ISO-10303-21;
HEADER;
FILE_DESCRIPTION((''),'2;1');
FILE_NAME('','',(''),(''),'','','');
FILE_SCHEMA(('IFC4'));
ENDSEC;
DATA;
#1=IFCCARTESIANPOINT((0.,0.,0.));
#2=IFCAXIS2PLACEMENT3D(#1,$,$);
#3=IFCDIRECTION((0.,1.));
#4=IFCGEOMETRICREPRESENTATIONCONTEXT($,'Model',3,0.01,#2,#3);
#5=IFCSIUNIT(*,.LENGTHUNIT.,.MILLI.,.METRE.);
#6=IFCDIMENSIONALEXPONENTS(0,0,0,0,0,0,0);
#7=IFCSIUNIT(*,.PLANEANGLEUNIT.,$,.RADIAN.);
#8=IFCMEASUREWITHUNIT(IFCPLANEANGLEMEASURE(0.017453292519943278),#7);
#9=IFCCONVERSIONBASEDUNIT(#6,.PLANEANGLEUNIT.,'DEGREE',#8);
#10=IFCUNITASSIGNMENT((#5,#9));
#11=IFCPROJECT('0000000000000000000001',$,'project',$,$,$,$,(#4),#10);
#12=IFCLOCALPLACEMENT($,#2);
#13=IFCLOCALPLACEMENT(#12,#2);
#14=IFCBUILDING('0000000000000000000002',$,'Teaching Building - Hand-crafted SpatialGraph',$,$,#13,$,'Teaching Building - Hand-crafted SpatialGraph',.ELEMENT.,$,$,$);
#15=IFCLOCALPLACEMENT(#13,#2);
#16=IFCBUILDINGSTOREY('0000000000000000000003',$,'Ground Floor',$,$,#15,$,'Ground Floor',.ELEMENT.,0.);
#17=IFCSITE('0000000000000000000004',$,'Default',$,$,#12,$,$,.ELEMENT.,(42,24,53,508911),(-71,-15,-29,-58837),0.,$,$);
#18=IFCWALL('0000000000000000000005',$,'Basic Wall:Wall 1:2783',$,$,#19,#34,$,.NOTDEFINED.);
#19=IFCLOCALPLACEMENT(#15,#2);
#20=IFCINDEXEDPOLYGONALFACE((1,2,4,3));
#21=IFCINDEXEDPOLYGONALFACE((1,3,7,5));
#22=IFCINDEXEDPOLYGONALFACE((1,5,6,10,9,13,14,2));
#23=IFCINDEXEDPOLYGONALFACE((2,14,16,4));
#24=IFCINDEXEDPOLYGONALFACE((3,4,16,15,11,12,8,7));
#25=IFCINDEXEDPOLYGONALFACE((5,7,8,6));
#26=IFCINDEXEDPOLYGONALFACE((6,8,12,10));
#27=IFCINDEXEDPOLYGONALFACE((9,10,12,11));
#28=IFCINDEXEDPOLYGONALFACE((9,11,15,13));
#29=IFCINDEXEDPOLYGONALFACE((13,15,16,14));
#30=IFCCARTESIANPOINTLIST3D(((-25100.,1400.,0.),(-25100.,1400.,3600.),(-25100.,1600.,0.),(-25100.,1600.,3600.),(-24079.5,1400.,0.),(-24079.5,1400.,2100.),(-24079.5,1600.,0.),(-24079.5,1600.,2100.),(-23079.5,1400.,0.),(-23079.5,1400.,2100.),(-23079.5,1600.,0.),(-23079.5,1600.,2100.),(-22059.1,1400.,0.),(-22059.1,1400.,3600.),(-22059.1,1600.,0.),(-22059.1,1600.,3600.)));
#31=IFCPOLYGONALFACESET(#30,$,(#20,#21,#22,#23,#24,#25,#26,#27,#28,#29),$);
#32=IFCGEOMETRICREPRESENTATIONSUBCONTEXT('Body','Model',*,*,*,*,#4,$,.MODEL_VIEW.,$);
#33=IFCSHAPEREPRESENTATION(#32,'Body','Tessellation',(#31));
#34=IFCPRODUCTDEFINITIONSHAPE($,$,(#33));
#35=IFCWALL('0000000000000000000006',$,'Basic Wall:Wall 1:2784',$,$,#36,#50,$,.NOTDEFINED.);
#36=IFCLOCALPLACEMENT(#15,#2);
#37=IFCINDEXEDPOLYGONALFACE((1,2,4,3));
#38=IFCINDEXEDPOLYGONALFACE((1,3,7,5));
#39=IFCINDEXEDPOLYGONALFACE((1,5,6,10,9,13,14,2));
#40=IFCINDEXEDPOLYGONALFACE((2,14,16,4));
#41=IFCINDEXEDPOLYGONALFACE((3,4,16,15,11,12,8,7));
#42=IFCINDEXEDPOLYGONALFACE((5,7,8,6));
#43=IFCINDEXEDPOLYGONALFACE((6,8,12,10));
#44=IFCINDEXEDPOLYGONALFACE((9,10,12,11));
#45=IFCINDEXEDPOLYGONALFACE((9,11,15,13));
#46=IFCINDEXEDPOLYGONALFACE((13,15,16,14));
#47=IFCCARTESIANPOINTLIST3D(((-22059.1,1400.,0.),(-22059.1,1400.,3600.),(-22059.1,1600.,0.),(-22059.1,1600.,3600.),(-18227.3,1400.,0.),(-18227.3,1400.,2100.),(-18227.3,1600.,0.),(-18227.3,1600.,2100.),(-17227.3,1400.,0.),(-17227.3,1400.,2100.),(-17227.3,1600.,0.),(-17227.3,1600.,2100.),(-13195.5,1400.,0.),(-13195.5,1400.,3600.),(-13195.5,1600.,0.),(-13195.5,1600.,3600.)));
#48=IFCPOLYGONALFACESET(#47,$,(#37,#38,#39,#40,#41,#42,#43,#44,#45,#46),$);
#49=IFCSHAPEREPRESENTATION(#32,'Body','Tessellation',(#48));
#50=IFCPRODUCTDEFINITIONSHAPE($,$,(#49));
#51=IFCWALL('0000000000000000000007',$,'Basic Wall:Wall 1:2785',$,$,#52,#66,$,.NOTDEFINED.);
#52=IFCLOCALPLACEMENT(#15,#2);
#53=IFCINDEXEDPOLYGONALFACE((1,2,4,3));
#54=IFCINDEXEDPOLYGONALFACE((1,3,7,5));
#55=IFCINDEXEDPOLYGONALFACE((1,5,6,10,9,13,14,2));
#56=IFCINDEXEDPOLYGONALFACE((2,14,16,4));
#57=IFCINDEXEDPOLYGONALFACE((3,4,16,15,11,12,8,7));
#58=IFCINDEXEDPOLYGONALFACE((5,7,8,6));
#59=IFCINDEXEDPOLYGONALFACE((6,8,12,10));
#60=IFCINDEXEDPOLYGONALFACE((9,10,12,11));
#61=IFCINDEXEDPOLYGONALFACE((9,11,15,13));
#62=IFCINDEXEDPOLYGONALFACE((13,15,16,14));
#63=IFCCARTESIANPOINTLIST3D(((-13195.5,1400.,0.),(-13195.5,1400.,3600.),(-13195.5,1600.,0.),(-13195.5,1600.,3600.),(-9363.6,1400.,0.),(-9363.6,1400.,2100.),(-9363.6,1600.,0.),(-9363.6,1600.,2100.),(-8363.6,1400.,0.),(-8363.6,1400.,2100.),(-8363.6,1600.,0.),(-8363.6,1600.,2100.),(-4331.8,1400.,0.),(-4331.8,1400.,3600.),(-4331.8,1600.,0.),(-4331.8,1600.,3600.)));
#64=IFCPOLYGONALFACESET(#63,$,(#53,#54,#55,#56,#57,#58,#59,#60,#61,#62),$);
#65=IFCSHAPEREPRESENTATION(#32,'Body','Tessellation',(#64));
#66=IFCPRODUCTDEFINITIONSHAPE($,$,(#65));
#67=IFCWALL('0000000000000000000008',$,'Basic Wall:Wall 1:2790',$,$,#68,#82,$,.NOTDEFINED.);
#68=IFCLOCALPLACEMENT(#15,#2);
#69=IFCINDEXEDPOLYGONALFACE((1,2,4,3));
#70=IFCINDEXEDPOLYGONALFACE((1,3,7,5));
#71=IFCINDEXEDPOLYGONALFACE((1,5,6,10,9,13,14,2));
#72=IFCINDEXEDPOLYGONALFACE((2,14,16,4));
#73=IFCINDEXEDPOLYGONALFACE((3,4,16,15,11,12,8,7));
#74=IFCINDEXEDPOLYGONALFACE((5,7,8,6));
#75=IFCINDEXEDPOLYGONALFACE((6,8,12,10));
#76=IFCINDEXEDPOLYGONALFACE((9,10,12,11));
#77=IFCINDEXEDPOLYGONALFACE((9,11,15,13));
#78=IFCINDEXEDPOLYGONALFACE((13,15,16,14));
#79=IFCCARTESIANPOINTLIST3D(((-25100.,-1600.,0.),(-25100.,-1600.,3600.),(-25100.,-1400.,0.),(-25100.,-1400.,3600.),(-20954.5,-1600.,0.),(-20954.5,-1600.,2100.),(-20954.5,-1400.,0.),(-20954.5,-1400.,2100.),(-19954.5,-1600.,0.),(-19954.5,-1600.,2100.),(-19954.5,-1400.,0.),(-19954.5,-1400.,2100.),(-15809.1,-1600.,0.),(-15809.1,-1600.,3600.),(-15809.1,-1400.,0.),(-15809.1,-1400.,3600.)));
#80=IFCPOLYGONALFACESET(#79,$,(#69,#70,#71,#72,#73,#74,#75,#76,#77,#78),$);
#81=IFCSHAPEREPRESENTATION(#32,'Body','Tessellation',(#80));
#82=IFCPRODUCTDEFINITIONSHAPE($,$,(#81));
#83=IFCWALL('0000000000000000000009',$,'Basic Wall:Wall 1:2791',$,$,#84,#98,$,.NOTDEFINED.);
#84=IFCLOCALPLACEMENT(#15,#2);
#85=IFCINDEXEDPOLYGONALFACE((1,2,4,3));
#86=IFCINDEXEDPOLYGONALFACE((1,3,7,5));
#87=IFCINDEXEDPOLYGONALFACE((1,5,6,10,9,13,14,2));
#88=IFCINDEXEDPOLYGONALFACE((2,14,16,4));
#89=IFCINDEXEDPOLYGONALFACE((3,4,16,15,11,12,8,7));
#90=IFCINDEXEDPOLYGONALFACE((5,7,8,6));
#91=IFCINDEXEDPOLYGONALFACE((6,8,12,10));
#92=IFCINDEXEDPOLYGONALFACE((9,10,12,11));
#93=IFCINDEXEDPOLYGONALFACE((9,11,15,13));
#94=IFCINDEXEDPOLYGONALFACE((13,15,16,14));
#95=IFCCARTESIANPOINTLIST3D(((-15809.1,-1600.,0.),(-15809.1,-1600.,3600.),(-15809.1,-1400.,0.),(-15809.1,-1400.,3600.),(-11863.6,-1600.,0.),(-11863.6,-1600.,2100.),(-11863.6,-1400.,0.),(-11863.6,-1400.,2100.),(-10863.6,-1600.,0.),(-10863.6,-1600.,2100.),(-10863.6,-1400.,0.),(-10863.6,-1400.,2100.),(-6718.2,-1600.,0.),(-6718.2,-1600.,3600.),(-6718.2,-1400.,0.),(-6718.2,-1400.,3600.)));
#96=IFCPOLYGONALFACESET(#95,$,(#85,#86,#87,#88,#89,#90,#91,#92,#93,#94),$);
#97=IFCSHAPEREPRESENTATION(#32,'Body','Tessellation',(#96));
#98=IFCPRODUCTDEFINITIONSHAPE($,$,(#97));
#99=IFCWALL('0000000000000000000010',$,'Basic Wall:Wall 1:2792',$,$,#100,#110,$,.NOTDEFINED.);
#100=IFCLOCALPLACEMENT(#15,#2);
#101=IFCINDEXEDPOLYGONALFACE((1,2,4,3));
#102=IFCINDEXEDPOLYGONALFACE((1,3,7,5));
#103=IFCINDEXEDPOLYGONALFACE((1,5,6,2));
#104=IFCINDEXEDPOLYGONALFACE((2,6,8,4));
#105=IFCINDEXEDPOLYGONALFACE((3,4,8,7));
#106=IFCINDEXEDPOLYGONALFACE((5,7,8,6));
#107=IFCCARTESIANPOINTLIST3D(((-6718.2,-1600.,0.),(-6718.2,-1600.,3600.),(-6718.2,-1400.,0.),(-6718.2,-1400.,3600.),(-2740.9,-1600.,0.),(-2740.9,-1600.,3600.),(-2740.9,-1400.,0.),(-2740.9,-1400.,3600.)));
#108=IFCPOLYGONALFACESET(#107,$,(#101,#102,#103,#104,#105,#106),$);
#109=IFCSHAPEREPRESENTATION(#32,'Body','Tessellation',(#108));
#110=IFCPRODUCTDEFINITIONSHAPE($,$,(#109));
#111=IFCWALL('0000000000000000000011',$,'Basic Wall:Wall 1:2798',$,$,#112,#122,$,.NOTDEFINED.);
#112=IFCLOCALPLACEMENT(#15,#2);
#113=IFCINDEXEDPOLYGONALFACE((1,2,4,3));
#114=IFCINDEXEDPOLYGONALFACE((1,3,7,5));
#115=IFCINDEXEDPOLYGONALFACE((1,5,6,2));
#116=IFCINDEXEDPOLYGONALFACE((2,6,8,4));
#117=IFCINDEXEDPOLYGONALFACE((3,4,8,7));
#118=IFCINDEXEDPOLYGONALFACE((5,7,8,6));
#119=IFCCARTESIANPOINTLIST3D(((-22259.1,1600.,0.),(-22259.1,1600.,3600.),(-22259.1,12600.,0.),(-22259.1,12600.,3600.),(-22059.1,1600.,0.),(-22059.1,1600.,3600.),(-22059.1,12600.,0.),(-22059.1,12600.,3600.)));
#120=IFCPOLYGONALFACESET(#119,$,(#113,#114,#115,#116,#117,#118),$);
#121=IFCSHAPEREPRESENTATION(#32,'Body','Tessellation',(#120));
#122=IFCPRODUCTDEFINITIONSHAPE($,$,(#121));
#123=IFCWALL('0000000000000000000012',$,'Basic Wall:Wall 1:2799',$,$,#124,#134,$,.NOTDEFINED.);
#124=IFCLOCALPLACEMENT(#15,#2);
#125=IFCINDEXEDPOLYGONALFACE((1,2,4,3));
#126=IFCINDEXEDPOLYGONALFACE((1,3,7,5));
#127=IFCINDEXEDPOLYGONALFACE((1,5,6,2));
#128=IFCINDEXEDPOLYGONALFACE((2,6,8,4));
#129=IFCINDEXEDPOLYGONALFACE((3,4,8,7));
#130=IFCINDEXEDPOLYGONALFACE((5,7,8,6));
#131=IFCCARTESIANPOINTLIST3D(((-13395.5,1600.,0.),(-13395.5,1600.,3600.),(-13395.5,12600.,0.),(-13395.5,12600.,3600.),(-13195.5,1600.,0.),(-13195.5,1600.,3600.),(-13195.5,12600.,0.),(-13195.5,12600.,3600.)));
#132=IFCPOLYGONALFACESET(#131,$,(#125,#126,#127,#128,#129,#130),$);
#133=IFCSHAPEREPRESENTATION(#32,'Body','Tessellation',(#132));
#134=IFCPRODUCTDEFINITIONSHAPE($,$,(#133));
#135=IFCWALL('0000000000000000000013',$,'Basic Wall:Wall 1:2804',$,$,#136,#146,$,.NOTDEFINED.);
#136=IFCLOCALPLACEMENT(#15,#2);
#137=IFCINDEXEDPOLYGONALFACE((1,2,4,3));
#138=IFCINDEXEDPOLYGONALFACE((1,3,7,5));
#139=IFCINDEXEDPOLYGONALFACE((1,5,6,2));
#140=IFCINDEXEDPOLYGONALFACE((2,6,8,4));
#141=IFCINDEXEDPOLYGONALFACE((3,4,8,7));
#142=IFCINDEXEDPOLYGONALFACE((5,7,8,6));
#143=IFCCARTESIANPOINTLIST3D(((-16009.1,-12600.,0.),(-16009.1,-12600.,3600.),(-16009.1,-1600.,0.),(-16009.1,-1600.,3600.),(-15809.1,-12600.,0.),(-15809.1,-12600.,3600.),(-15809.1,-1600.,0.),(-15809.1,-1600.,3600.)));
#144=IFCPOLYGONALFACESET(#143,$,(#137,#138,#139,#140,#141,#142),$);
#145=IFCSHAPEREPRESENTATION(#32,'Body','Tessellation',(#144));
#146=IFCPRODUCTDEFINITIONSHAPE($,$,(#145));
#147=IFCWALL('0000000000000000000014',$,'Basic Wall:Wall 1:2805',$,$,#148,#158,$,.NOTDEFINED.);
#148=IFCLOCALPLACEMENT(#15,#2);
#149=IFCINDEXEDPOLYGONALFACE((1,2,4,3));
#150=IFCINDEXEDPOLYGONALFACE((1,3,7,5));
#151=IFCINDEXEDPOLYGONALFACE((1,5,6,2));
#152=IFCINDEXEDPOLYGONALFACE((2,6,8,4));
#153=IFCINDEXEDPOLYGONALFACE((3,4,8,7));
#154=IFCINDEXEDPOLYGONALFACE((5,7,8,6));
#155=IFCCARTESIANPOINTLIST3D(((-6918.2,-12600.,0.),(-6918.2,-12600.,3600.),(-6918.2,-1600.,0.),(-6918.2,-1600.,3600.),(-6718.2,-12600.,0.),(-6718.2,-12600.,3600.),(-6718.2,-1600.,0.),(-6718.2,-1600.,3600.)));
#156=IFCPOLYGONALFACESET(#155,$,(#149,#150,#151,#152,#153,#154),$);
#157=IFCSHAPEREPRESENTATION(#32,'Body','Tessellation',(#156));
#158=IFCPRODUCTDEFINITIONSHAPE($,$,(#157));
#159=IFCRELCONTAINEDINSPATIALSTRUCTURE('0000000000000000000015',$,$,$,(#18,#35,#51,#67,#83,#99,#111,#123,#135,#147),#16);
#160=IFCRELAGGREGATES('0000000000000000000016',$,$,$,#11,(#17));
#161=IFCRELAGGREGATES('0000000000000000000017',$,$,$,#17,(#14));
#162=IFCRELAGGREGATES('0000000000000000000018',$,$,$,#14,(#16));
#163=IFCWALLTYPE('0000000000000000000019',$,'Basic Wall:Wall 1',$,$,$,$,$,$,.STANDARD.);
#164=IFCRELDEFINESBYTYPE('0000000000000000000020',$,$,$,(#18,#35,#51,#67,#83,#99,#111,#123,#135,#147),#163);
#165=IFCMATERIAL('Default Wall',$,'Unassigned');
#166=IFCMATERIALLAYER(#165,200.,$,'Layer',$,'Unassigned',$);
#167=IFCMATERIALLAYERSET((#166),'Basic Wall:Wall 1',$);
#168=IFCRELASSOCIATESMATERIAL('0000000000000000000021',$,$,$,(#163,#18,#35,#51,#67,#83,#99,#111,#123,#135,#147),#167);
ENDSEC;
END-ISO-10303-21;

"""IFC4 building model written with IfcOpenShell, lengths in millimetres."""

from ifc_helpers import new_model, entity, si_unit, converted_unit, direction, frame, frame_2d, origin, origin_2d_with_axis, place, context, subcontext, project, spatial, rectangle, extrude, material, layer, layer_set, layer_usage, type_object, element, save


model = new_model("IFC4")

# Units and contexts
model_context = context("Model", 3, precision=0.01, world=origin(), true_north=direction((0.0, 1.0)))
body_context = subcontext(model_context, "Body", "Model", "MODEL_VIEW")
ifc_project = project(units=[si_unit("LENGTHUNIT", "METRE", prefix="MILLI"), converted_unit("PLANEANGLEUNIT", "DEGREE", entity("IfcPlaneAngleMeasure", 0.017453292519943278), si_unit("PLANEANGLEUNIT", "RADIAN"), dimensions=[0, 0, 0, 0, 0, 0, 0])], contexts=[model_context])

# Site, building, storey
site_placement = place(None, origin())
site = spatial("IfcSite", under=ifc_project, at=site_placement, Name="Default", CompositionType="ELEMENT", RefLatitude=(42, 24, 53, 508911), RefLongitude=(-71, -15, -29, -58837), RefElevation=0.0)
building_placement = place(site_placement, origin())
building = spatial("IfcBuilding", under=site, at=building_placement, Name="Teaching Building - Hand-crafted SpatialGraph", LongName="Teaching Building - Hand-crafted SpatialGraph", CompositionType="ELEMENT")
storey_placement = place(building_placement, origin())
storey = spatial("IfcBuildingStorey", under=building, at=storey_placement, Name="Ground Floor", LongName="Ground Floor", CompositionType="ELEMENT", Elevation=0.0)

# Walls, openings
ifc_material = material(Name="Default Wall", Category="Unassigned")
ifc_layer = layer(ifc_material, 200.0, Name="Layer", Category="Unassigned")
ifc_layer_set = layer_set([ifc_layer], Name="Basic Wall:Wall 1")
ifc_layer_usage_1 = layer_usage(ifc_layer_set, "AXIS2", "NEGATIVE", 100.0)
wall_type = type_object("IfcWallType", Name="Basic Wall:Wall 1", PredefinedType="STANDARD", material=ifc_layer_set)
wall_1_placement = place(storey_placement, frame((-25100.0, 1500.0, 0.0)))
wall_1 = element("IfcWall", 1, at=wall_1_placement, inside=storey, type_object=wall_type, material=ifc_layer_usage_1, Name="Basic Wall:Wall 1:2783", PredefinedType="NOTDEFINED", context=body_context, shape_type="SweptSolid", body=[
    extrude(rectangle(XDim=3040.9, YDim=200.0, at=frame_2d((1520.5, 0.0), x_axis=(1.0, 0.0))), origin(), (0.0, 0.0, 1.0), 3600.0),
])
opening_1_placement = place(wall_1_placement, origin())
element("IfcOpeningElement", 2, at=opening_1_placement, cuts=wall_1, PredefinedType="OPENING", context=body_context, shape_type="SweptSolid", body=[
    extrude(rectangle(XDim=2100.0, YDim=1000.0, at=frame_2d((0.0, 0.0), x_axis=(1.0, 0.0))), frame((1520.5, -100.0, 1050.0), z_axis=(0.0, 1.0, 0.0), x_axis=(0.0, 0.0, -1.0)), (0.0, 0.0, 1.0), 200.0),
])
ifc_layer_usage_2 = layer_usage(ifc_layer_set, "AXIS2", "NEGATIVE", 100.0)
wall_2_placement = place(storey_placement, frame((-22059.1, 1500.0, 0.0)))
wall_2 = element("IfcWall", 3, at=wall_2_placement, inside=storey, type_object=wall_type, material=ifc_layer_usage_2, Name="Basic Wall:Wall 1:2784", PredefinedType="NOTDEFINED", context=body_context, shape_type="SweptSolid", body=[
    extrude(rectangle(XDim=8863.6, YDim=200.0, at=frame_2d((4431.8, 0.0), x_axis=(1.0, 0.0))), origin(), (0.0, 0.0, 1.0), 3600.0),
])
opening_2_placement = place(wall_2_placement, origin())
element("IfcOpeningElement", 4, at=opening_2_placement, cuts=wall_2, PredefinedType="OPENING", context=body_context, shape_type="SweptSolid", body=[
    extrude(rectangle(XDim=2100.0, YDim=1000.0, at=frame_2d((0.0, 0.0), x_axis=(1.0, 0.0))), frame((4331.8, -100.0, 1050.0), z_axis=(0.0, 1.0, 0.0), x_axis=(0.0, 0.0, -1.0)), (0.0, 0.0, 1.0), 200.0),
])
ifc_layer_usage_3 = layer_usage(ifc_layer_set, "AXIS2", "NEGATIVE", 100.0)
wall_3_placement = place(storey_placement, frame((-13195.5, 1500.0, 0.0)))
wall_3 = element("IfcWall", 5, at=wall_3_placement, inside=storey, type_object=wall_type, material=ifc_layer_usage_3, Name="Basic Wall:Wall 1:2785", PredefinedType="NOTDEFINED", context=body_context, shape_type="SweptSolid", body=[
    extrude(rectangle(XDim=8863.6, YDim=200.0, at=frame_2d((4431.8, 0.0), x_axis=(1.0, 0.0))), origin(), (0.0, 0.0, 1.0), 3600.0),
])
opening_3_placement = place(wall_3_placement, origin())
element("IfcOpeningElement", 6, at=opening_3_placement, cuts=wall_3, PredefinedType="OPENING", context=body_context, shape_type="SweptSolid", body=[
    extrude(rectangle(XDim=2100.0, YDim=1000.0, at=origin_2d_with_axis()), frame((4331.8, -100.0, 1050.0), z_axis=(0.0, 1.0, 0.0), x_axis=(0.0, 0.0, -1.0)), (0.0, 0.0, 1.0), 200.0),
])
ifc_layer_usage_4 = layer_usage(ifc_layer_set, "AXIS2", "NEGATIVE", 100.0)
wall_4_placement = place(storey_placement, frame((-25100.0, -1500.0, 0.0)))
wall_4 = element("IfcWall", 7, at=wall_4_placement, inside=storey, type_object=wall_type, material=ifc_layer_usage_4, Name="Basic Wall:Wall 1:2790", PredefinedType="NOTDEFINED", context=body_context, shape_type="SweptSolid", body=[
    extrude(rectangle(XDim=9290.9, YDim=200.0, at=frame_2d((4645.5, 0.0), x_axis=(1.0, 0.0))), origin(), (0.0, 0.0, 1.0), 3600.0),
])
opening_4_placement = place(wall_4_placement, origin())
element("IfcOpeningElement", 8, at=opening_4_placement, cuts=wall_4, PredefinedType="OPENING", context=body_context, shape_type="SweptSolid", body=[
    extrude(rectangle(XDim=2100.0, YDim=1000.0, at=frame_2d((0.0, 0.0), x_axis=(1.0, 0.0))), frame((4645.5, -100.0, 1050.0), z_axis=(0.0, 1.0, 0.0), x_axis=(0.0, 0.0, -1.0)), (0.0, 0.0, 1.0), 200.0),
])
ifc_layer_usage_5 = layer_usage(ifc_layer_set, "AXIS2", "NEGATIVE", 100.0)
wall_5_placement = place(storey_placement, frame((-15809.1, -1500.0, 0.0)))
wall_5 = element("IfcWall", 9, at=wall_5_placement, inside=storey, type_object=wall_type, material=ifc_layer_usage_5, Name="Basic Wall:Wall 1:2791", PredefinedType="NOTDEFINED", context=body_context, shape_type="SweptSolid", body=[
    extrude(rectangle(XDim=9090.9, YDim=200.0, at=frame_2d((4545.5, 0.0), x_axis=(1.0, 0.0))), origin(), (0.0, 0.0, 1.0), 3600.0),
])
opening_5_placement = place(wall_5_placement, origin())
element("IfcOpeningElement", 10, at=opening_5_placement, cuts=wall_5, PredefinedType="OPENING", context=body_context, shape_type="SweptSolid", body=[
    extrude(rectangle(XDim=2100.0, YDim=1000.0, at=frame_2d((0.0, 0.0), x_axis=(1.0, 0.0))), frame((4445.5, -100.0, 1050.0), z_axis=(0.0, 1.0, 0.0), x_axis=(0.0, 0.0, -1.0)), (0.0, 0.0, 1.0), 200.0),
])

# Walls
ifc_layer_usage_6 = layer_usage(ifc_layer_set, "AXIS2", "NEGATIVE", 100.0)
wall_6_placement = place(storey_placement, frame((-6718.2, -1500.0, 0.0)))
element("IfcWall", 11, at=wall_6_placement, inside=storey, type_object=wall_type, material=ifc_layer_usage_6, Name="Basic Wall:Wall 1:2792", PredefinedType="NOTDEFINED", context=body_context, shape_type="SweptSolid", body=[
    extrude(rectangle(XDim=3977.3, YDim=200.0, at=frame_2d((1988.6, 0.0), x_axis=(-1.0, 0.0))), origin(), (0.0, 0.0, 1.0), 3600.0),
])
ifc_layer_usage_7 = layer_usage(ifc_layer_set, "AXIS2", "NEGATIVE", 100.0)
wall_7_placement = place(storey_placement, frame((-22159.1, 1600.0, 0.0), z_axis=(0.0, 0.0, 1.0), x_axis=(0.0, 1.0, 0.0)))
element("IfcWall", 12, at=wall_7_placement, inside=storey, type_object=wall_type, material=ifc_layer_usage_7, Name="Basic Wall:Wall 1:2798", PredefinedType="NOTDEFINED", context=body_context, shape_type="SweptSolid", body=[
    extrude(rectangle(XDim=11000.0, YDim=200.0, at=frame_2d((5500.0, 0.0), x_axis=(-1.0, 0.0))), origin(), (0.0, 0.0, 1.0), 3600.0),
])
ifc_layer_usage_8 = layer_usage(ifc_layer_set, "AXIS2", "NEGATIVE", 100.0)
wall_8_placement = place(storey_placement, frame((-13295.5, 1600.0, 0.0), z_axis=(0.0, 0.0, 1.0), x_axis=(0.0, 1.0, 0.0)))
element("IfcWall", 13, at=wall_8_placement, inside=storey, type_object=wall_type, material=ifc_layer_usage_8, Name="Basic Wall:Wall 1:2799", PredefinedType="NOTDEFINED", context=body_context, shape_type="SweptSolid", body=[
    extrude(rectangle(XDim=11000.0, YDim=200.0, at=frame_2d((5500.0, 0.0), x_axis=(-1.0, 0.0))), origin(), (0.0, 0.0, 1.0), 3600.0),
])
ifc_layer_usage_9 = layer_usage(ifc_layer_set, "AXIS2", "NEGATIVE", 100.0)
wall_9_placement = place(storey_placement, frame((-15909.1, -12600.0, 0.0), z_axis=(0.0, 0.0, 1.0), x_axis=(0.0, 1.0, 0.0)))
element("IfcWall", 14, at=wall_9_placement, inside=storey, type_object=wall_type, material=ifc_layer_usage_9, Name="Basic Wall:Wall 1:2804", PredefinedType="NOTDEFINED", context=body_context, shape_type="SweptSolid", body=[
    extrude(rectangle(XDim=11000.0, YDim=200.0, at=frame_2d((5500.0, 0.0), x_axis=(-1.0, 0.0))), origin(), (0.0, 0.0, 1.0), 3600.0),
])
ifc_layer_usage_10 = layer_usage(ifc_layer_set, "AXIS2", "NEGATIVE", 100.0)
wall_10_placement = place(storey_placement, frame((-6818.2, -12600.0, 0.0), z_axis=(0.0, 0.0, 1.0), x_axis=(0.0, 1.0, 0.0)))
element("IfcWall", 15, at=wall_10_placement, inside=storey, type_object=wall_type, material=ifc_layer_usage_10, Name="Basic Wall:Wall 1:2805", PredefinedType="NOTDEFINED", context=body_context, shape_type="SweptSolid", body=[
    extrude(rectangle(XDim=11000.0, YDim=200.0, at=frame_2d((5500.0, 0.0), x_axis=(-1.0, 0.0))), origin(), (0.0, 0.0, 1.0), 3600.0),
])

save(model, "model.ifc")
